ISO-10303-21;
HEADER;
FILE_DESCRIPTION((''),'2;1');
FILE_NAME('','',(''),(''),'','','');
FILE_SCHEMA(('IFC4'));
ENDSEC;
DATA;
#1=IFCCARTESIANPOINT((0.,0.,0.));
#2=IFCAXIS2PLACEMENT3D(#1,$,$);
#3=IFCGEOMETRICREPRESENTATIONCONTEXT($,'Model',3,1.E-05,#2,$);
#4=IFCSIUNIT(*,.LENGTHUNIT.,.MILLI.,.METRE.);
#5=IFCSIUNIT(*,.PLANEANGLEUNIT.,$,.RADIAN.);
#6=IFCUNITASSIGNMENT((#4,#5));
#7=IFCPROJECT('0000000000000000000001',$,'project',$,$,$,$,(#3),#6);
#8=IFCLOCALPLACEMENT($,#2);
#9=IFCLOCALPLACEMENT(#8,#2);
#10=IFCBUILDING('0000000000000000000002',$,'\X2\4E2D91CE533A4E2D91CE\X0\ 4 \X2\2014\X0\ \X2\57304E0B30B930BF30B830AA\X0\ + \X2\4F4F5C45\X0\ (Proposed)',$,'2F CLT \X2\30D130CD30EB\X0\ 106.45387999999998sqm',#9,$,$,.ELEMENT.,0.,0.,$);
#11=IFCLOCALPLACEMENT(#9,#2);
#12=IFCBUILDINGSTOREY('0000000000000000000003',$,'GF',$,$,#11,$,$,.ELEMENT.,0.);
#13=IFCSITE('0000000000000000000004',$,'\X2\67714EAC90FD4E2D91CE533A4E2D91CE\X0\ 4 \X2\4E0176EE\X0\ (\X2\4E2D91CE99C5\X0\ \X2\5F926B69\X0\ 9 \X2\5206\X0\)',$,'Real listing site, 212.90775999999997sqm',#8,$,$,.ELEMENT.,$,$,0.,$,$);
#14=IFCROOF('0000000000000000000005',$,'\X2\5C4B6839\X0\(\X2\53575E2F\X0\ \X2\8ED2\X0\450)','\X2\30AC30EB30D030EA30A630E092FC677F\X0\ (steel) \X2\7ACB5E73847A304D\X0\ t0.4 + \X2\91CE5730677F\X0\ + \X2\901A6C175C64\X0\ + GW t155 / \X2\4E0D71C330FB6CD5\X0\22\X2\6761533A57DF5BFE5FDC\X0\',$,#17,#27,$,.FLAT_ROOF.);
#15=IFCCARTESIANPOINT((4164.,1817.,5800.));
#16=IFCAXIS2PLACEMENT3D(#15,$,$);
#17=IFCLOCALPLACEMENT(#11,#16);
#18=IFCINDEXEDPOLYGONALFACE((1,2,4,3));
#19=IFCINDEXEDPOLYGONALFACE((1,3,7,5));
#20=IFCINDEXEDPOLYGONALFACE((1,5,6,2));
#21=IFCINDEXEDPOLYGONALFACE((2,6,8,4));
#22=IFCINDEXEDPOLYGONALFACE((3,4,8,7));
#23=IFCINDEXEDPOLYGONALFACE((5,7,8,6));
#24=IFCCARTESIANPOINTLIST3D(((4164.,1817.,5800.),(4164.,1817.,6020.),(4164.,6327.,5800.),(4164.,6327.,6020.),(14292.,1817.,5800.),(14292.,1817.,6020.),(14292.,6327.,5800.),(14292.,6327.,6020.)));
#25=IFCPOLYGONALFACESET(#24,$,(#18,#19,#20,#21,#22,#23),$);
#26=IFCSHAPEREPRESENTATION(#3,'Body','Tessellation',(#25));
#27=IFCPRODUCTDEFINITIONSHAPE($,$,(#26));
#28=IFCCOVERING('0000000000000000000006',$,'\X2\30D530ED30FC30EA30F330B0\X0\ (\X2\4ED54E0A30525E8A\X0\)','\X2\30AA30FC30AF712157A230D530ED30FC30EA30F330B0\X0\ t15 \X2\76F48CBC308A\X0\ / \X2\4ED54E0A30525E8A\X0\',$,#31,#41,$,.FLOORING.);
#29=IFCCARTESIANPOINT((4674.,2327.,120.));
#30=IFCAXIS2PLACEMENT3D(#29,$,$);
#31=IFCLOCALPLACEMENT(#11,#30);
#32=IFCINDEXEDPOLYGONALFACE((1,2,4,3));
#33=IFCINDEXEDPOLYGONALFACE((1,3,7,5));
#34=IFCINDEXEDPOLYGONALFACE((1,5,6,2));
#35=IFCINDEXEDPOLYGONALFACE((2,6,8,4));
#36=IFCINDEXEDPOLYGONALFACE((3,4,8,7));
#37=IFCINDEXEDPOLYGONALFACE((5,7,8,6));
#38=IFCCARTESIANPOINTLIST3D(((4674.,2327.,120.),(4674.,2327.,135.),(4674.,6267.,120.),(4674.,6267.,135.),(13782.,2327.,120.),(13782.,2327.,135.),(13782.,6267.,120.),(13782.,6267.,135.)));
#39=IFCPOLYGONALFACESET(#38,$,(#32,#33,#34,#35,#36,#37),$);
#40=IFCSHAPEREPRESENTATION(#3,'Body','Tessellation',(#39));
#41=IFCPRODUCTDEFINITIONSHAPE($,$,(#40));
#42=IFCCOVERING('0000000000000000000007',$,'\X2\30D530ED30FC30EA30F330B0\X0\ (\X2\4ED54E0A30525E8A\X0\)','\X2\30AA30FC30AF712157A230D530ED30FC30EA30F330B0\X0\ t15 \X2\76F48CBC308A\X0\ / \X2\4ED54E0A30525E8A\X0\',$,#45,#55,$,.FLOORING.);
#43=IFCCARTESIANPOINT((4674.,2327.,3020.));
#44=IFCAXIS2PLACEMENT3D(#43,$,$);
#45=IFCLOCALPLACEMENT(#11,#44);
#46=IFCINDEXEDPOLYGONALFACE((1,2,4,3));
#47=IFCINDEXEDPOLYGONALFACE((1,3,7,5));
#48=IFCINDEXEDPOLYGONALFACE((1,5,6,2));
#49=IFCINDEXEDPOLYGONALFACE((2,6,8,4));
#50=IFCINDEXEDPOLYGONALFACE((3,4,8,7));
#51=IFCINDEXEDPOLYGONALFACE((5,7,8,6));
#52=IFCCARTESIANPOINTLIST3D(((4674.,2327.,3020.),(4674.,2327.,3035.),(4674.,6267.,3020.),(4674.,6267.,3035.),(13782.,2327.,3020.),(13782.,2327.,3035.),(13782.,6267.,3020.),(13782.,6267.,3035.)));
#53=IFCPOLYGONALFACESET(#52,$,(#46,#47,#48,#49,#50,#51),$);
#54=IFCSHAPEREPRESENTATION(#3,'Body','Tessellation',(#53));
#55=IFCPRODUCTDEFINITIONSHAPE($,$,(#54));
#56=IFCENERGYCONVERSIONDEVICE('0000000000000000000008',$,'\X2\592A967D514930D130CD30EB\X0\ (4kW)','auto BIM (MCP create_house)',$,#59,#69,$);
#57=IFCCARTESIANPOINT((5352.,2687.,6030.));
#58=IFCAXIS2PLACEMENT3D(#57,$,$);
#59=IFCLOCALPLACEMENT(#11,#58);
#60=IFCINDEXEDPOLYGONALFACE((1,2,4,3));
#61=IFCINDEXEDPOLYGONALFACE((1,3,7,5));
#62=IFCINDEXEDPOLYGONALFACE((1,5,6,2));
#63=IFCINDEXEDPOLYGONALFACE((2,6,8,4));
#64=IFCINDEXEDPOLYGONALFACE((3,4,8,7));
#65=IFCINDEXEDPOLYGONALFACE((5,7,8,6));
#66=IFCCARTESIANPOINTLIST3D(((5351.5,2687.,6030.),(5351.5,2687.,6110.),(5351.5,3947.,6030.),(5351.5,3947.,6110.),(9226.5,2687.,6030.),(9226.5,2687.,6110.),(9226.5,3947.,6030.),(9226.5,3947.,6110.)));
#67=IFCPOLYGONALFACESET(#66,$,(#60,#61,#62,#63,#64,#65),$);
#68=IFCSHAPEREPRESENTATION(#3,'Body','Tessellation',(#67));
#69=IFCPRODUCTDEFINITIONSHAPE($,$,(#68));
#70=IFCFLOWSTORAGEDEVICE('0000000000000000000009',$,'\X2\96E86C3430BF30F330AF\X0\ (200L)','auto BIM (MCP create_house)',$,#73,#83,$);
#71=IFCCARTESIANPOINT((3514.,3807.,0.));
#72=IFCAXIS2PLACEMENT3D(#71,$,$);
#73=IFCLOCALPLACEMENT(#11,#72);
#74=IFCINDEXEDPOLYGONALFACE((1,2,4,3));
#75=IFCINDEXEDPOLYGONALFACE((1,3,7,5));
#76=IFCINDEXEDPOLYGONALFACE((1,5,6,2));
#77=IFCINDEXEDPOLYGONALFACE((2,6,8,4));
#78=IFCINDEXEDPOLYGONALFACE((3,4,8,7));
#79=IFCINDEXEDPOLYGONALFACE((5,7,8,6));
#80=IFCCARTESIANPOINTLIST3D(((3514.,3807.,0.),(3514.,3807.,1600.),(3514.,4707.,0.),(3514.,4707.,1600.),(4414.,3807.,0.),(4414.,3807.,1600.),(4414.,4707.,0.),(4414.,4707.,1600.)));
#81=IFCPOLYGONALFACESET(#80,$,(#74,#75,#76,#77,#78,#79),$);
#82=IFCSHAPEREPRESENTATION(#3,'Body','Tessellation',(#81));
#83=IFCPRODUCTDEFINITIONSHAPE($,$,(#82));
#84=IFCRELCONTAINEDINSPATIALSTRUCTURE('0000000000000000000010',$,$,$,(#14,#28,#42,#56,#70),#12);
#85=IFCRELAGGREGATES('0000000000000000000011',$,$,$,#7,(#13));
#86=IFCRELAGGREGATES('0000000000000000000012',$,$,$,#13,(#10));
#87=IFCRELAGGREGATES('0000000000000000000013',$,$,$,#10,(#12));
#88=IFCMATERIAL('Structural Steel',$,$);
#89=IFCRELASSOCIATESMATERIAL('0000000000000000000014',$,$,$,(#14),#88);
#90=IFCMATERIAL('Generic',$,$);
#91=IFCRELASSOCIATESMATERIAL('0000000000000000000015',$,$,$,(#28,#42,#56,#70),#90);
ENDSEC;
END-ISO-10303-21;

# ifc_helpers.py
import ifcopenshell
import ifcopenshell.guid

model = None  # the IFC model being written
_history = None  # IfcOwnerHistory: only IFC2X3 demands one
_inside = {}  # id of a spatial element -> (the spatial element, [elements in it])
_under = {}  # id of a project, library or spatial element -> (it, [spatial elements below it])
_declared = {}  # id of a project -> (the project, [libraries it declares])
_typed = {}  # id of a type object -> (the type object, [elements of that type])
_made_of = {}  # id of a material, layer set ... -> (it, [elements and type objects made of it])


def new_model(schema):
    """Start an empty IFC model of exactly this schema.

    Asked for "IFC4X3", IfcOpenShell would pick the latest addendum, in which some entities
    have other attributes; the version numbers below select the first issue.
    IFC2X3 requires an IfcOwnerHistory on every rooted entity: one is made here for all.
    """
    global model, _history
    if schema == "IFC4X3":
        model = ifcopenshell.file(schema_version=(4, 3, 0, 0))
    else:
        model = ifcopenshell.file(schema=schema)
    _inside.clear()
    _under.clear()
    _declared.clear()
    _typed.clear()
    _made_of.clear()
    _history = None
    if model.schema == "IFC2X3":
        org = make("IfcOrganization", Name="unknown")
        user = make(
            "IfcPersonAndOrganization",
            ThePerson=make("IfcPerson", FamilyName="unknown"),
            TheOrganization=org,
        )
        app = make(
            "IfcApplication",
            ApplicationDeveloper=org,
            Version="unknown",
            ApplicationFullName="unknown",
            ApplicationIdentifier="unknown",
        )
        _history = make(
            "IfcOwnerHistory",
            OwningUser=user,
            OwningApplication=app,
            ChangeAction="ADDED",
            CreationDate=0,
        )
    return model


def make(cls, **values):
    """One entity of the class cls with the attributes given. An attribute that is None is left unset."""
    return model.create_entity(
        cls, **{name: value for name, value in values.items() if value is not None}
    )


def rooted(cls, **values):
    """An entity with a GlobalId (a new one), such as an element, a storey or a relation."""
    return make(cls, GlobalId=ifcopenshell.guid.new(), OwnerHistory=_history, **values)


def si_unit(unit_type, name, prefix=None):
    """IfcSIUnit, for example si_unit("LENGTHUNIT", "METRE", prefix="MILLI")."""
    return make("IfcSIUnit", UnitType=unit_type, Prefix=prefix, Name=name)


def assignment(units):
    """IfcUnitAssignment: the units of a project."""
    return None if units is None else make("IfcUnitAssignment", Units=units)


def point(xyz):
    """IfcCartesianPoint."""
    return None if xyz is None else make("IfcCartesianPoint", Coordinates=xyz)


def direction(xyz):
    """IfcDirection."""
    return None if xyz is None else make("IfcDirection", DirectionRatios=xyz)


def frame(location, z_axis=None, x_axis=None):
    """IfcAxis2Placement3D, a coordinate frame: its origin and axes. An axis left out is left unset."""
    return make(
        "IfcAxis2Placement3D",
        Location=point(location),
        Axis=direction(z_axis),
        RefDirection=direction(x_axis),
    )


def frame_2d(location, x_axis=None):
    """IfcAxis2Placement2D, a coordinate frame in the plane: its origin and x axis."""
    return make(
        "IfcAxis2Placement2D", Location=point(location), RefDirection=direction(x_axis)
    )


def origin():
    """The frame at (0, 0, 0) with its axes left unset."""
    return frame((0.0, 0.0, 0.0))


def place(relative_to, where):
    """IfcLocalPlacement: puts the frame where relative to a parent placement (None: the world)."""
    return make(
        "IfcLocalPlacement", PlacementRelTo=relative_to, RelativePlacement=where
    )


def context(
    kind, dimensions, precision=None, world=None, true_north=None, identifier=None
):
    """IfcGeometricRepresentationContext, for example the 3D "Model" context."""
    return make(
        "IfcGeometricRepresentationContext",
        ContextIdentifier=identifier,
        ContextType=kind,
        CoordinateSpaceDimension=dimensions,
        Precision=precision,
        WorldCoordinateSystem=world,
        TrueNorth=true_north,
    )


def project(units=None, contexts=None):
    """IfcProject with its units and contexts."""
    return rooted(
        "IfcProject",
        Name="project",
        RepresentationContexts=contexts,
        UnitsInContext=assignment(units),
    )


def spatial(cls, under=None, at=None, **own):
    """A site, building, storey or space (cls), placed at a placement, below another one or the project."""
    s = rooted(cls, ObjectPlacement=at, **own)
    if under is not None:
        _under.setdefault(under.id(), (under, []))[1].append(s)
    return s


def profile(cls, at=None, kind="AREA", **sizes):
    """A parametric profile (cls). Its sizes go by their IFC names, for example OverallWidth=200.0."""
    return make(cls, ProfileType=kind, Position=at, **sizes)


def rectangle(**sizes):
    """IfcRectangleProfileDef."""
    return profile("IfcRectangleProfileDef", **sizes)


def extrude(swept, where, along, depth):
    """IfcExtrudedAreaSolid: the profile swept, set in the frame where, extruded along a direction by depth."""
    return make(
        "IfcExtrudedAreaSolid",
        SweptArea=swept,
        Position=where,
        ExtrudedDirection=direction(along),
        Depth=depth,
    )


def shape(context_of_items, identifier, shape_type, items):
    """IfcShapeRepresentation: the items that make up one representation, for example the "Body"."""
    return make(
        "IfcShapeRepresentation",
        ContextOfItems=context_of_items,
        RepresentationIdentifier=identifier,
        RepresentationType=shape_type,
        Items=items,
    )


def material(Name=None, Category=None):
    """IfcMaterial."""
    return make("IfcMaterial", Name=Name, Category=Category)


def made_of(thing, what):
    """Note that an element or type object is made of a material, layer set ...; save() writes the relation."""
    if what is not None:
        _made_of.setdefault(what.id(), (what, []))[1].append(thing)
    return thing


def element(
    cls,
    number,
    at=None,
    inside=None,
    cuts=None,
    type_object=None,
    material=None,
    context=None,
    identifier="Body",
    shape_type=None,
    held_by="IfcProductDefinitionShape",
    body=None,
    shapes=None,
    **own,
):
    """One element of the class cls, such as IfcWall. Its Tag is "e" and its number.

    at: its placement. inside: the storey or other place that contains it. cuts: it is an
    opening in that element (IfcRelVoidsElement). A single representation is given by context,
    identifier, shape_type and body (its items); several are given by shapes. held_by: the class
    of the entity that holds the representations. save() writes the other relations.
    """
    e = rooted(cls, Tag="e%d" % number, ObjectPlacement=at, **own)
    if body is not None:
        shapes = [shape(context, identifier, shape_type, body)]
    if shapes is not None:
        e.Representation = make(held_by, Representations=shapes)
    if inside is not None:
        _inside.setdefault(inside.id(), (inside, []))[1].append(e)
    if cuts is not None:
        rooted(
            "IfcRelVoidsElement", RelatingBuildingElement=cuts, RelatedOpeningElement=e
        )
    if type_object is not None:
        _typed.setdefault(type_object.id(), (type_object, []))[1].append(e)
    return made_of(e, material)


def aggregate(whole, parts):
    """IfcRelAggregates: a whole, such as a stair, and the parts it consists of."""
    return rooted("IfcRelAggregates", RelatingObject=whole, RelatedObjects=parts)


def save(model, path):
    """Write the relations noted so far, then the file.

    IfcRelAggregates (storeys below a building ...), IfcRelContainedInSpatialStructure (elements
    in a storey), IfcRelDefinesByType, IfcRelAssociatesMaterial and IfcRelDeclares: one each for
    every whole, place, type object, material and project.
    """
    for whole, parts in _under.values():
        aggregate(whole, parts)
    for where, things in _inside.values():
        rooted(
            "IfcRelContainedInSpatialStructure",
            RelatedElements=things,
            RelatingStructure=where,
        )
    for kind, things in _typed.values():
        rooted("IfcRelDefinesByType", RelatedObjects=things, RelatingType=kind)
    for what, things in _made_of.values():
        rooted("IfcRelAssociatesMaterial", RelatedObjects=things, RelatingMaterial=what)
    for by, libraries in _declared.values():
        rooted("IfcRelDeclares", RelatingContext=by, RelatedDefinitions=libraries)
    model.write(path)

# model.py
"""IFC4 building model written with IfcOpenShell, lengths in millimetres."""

from ifc_helpers import new_model, si_unit, frame, frame_2d, origin, place, context, project, spatial, rectangle, extrude, material, element, save


model = new_model("IFC4")

# Units and contexts
model_context = context("Model", 3, precision=1e-05, world=origin())
ifc_project = project(units=[si_unit("LENGTHUNIT", "METRE", prefix="MILLI"), si_unit("PLANEANGLEUNIT", "RADIAN")], contexts=[model_context])

# Site, building, storey
site_placement = place(None, origin())
site = spatial("IfcSite", under=ifc_project, at=site_placement, Name="東京都中野区中野 4 丁目 (中野駅 徒歩 9 分)", ObjectType="Real listing site, 212.90775999999997sqm", CompositionType="ELEMENT", RefElevation=0.0)
building_placement = place(site_placement, origin())
building = spatial("IfcBuilding", under=site, at=building_placement, Name="中野区中野 4 — 地下スタジオ + 住居 (Proposed)", ObjectType="2F CLT パネル 106.45387999999998sqm", CompositionType="ELEMENT", ElevationOfRefHeight=0.0, ElevationOfTerrain=0.0)
storey_placement = place(building_placement, origin())
storey = spatial("IfcBuildingStorey", under=building, at=storey_placement, Name="GF", CompositionType="ELEMENT", Elevation=0.0)

# Roof
ifc_material_1 = material(Name="Structural Steel")
for number, where, name in (
    (1, (4164.0, 1817.0, 5800.0), "屋根(南帯 軒450)"),
):
    element("IfcRoof", number, at=place(storey_placement, frame(where)), inside=storey, material=ifc_material_1, Name=name, Description="ガルバリウム鋼板 (steel) 立平葺き t0.4 + 野地板 + 通気層 + GW t155 / 不燃・法22条区域対応", PredefinedType="FLAT_ROOF", context=model_context, shape_type="SweptSolid", body=[
        extrude(rectangle(XDim=10128.0, YDim=4510.0, at=frame_2d((5064.0, 2255.0))), frame((4164.0, 1817.0, 5800.0)), (0.0, 0.0, 1.0), 220.0),
    ])

# Coverings
ifc_material_2 = material(Name="Generic")
covering_1_placement = place(storey_placement, frame((4674.0, 2327.0, 120.0)))
element("IfcCovering", 2, at=covering_1_placement, inside=storey, material=ifc_material_2, Name="フローリング (仕上げ床)", Description="オーク無垢フローリング t15 直貼り / 仕上げ床", PredefinedType="FLOORING", context=model_context, shape_type="SweptSolid", body=[
    extrude(rectangle(XDim=9108.0, YDim=3940.0, at=frame_2d((4554.0, 1970.0))), frame((4674.0, 2327.0, 120.0)), (0.0, 0.0, 1.0), 15.0),
])
covering_2_placement = place(storey_placement, frame((4674.0, 2327.0, 3020.0)))
element("IfcCovering", 3, at=covering_2_placement, inside=storey, material=ifc_material_2, Name="フローリング (仕上げ床)", Description="オーク無垢フローリング t15 直貼り / 仕上げ床", PredefinedType="FLOORING", context=model_context, shape_type="SweptSolid", body=[
    extrude(rectangle(XDim=9108.0, YDim=3940.0, at=frame_2d((4554.0, 1970.0))), frame((4674.0, 2327.0, 3020.0)), (0.0, 0.0, 1.0), 15.0),
])

# Energy conversion device
energy_conversion_device_placement = place(storey_placement, frame((5352.0, 2687.0, 6030.0)))
element("IfcEnergyConversionDevice", 4, at=energy_conversion_device_placement, inside=storey, material=ifc_material_2, Name="太陽光パネル (4kW)", Description="auto BIM (MCP create_house)", context=model_context, shape_type="SweptSolid", body=[
    extrude(rectangle(XDim=3875.0, YDim=1260.0, at=frame_2d((1937.0, 630.0))), frame((5352.0, 2687.0, 6030.0)), (0.0, 0.0, 1.0), 80.0),
])

# Flow storage device
flow_storage_device_placement = place(storey_placement, frame((3514.0, 3807.0, 0.0)))
element("IfcFlowStorageDevice", 5, at=flow_storage_device_placement, inside=storey, material=ifc_material_2, Name="雨水タンク (200L)", Description="auto BIM (MCP create_house)", context=model_context, shape_type="SweptSolid", body=[
    extrude(rectangle(XDim=900.0, YDim=900.0, at=frame_2d((450.0, 450.0))), frame((3514.0, 3807.0, 0.0)), (0.0, 0.0, 1.0), 1600.0),
])

save(model, "model.ifc")
